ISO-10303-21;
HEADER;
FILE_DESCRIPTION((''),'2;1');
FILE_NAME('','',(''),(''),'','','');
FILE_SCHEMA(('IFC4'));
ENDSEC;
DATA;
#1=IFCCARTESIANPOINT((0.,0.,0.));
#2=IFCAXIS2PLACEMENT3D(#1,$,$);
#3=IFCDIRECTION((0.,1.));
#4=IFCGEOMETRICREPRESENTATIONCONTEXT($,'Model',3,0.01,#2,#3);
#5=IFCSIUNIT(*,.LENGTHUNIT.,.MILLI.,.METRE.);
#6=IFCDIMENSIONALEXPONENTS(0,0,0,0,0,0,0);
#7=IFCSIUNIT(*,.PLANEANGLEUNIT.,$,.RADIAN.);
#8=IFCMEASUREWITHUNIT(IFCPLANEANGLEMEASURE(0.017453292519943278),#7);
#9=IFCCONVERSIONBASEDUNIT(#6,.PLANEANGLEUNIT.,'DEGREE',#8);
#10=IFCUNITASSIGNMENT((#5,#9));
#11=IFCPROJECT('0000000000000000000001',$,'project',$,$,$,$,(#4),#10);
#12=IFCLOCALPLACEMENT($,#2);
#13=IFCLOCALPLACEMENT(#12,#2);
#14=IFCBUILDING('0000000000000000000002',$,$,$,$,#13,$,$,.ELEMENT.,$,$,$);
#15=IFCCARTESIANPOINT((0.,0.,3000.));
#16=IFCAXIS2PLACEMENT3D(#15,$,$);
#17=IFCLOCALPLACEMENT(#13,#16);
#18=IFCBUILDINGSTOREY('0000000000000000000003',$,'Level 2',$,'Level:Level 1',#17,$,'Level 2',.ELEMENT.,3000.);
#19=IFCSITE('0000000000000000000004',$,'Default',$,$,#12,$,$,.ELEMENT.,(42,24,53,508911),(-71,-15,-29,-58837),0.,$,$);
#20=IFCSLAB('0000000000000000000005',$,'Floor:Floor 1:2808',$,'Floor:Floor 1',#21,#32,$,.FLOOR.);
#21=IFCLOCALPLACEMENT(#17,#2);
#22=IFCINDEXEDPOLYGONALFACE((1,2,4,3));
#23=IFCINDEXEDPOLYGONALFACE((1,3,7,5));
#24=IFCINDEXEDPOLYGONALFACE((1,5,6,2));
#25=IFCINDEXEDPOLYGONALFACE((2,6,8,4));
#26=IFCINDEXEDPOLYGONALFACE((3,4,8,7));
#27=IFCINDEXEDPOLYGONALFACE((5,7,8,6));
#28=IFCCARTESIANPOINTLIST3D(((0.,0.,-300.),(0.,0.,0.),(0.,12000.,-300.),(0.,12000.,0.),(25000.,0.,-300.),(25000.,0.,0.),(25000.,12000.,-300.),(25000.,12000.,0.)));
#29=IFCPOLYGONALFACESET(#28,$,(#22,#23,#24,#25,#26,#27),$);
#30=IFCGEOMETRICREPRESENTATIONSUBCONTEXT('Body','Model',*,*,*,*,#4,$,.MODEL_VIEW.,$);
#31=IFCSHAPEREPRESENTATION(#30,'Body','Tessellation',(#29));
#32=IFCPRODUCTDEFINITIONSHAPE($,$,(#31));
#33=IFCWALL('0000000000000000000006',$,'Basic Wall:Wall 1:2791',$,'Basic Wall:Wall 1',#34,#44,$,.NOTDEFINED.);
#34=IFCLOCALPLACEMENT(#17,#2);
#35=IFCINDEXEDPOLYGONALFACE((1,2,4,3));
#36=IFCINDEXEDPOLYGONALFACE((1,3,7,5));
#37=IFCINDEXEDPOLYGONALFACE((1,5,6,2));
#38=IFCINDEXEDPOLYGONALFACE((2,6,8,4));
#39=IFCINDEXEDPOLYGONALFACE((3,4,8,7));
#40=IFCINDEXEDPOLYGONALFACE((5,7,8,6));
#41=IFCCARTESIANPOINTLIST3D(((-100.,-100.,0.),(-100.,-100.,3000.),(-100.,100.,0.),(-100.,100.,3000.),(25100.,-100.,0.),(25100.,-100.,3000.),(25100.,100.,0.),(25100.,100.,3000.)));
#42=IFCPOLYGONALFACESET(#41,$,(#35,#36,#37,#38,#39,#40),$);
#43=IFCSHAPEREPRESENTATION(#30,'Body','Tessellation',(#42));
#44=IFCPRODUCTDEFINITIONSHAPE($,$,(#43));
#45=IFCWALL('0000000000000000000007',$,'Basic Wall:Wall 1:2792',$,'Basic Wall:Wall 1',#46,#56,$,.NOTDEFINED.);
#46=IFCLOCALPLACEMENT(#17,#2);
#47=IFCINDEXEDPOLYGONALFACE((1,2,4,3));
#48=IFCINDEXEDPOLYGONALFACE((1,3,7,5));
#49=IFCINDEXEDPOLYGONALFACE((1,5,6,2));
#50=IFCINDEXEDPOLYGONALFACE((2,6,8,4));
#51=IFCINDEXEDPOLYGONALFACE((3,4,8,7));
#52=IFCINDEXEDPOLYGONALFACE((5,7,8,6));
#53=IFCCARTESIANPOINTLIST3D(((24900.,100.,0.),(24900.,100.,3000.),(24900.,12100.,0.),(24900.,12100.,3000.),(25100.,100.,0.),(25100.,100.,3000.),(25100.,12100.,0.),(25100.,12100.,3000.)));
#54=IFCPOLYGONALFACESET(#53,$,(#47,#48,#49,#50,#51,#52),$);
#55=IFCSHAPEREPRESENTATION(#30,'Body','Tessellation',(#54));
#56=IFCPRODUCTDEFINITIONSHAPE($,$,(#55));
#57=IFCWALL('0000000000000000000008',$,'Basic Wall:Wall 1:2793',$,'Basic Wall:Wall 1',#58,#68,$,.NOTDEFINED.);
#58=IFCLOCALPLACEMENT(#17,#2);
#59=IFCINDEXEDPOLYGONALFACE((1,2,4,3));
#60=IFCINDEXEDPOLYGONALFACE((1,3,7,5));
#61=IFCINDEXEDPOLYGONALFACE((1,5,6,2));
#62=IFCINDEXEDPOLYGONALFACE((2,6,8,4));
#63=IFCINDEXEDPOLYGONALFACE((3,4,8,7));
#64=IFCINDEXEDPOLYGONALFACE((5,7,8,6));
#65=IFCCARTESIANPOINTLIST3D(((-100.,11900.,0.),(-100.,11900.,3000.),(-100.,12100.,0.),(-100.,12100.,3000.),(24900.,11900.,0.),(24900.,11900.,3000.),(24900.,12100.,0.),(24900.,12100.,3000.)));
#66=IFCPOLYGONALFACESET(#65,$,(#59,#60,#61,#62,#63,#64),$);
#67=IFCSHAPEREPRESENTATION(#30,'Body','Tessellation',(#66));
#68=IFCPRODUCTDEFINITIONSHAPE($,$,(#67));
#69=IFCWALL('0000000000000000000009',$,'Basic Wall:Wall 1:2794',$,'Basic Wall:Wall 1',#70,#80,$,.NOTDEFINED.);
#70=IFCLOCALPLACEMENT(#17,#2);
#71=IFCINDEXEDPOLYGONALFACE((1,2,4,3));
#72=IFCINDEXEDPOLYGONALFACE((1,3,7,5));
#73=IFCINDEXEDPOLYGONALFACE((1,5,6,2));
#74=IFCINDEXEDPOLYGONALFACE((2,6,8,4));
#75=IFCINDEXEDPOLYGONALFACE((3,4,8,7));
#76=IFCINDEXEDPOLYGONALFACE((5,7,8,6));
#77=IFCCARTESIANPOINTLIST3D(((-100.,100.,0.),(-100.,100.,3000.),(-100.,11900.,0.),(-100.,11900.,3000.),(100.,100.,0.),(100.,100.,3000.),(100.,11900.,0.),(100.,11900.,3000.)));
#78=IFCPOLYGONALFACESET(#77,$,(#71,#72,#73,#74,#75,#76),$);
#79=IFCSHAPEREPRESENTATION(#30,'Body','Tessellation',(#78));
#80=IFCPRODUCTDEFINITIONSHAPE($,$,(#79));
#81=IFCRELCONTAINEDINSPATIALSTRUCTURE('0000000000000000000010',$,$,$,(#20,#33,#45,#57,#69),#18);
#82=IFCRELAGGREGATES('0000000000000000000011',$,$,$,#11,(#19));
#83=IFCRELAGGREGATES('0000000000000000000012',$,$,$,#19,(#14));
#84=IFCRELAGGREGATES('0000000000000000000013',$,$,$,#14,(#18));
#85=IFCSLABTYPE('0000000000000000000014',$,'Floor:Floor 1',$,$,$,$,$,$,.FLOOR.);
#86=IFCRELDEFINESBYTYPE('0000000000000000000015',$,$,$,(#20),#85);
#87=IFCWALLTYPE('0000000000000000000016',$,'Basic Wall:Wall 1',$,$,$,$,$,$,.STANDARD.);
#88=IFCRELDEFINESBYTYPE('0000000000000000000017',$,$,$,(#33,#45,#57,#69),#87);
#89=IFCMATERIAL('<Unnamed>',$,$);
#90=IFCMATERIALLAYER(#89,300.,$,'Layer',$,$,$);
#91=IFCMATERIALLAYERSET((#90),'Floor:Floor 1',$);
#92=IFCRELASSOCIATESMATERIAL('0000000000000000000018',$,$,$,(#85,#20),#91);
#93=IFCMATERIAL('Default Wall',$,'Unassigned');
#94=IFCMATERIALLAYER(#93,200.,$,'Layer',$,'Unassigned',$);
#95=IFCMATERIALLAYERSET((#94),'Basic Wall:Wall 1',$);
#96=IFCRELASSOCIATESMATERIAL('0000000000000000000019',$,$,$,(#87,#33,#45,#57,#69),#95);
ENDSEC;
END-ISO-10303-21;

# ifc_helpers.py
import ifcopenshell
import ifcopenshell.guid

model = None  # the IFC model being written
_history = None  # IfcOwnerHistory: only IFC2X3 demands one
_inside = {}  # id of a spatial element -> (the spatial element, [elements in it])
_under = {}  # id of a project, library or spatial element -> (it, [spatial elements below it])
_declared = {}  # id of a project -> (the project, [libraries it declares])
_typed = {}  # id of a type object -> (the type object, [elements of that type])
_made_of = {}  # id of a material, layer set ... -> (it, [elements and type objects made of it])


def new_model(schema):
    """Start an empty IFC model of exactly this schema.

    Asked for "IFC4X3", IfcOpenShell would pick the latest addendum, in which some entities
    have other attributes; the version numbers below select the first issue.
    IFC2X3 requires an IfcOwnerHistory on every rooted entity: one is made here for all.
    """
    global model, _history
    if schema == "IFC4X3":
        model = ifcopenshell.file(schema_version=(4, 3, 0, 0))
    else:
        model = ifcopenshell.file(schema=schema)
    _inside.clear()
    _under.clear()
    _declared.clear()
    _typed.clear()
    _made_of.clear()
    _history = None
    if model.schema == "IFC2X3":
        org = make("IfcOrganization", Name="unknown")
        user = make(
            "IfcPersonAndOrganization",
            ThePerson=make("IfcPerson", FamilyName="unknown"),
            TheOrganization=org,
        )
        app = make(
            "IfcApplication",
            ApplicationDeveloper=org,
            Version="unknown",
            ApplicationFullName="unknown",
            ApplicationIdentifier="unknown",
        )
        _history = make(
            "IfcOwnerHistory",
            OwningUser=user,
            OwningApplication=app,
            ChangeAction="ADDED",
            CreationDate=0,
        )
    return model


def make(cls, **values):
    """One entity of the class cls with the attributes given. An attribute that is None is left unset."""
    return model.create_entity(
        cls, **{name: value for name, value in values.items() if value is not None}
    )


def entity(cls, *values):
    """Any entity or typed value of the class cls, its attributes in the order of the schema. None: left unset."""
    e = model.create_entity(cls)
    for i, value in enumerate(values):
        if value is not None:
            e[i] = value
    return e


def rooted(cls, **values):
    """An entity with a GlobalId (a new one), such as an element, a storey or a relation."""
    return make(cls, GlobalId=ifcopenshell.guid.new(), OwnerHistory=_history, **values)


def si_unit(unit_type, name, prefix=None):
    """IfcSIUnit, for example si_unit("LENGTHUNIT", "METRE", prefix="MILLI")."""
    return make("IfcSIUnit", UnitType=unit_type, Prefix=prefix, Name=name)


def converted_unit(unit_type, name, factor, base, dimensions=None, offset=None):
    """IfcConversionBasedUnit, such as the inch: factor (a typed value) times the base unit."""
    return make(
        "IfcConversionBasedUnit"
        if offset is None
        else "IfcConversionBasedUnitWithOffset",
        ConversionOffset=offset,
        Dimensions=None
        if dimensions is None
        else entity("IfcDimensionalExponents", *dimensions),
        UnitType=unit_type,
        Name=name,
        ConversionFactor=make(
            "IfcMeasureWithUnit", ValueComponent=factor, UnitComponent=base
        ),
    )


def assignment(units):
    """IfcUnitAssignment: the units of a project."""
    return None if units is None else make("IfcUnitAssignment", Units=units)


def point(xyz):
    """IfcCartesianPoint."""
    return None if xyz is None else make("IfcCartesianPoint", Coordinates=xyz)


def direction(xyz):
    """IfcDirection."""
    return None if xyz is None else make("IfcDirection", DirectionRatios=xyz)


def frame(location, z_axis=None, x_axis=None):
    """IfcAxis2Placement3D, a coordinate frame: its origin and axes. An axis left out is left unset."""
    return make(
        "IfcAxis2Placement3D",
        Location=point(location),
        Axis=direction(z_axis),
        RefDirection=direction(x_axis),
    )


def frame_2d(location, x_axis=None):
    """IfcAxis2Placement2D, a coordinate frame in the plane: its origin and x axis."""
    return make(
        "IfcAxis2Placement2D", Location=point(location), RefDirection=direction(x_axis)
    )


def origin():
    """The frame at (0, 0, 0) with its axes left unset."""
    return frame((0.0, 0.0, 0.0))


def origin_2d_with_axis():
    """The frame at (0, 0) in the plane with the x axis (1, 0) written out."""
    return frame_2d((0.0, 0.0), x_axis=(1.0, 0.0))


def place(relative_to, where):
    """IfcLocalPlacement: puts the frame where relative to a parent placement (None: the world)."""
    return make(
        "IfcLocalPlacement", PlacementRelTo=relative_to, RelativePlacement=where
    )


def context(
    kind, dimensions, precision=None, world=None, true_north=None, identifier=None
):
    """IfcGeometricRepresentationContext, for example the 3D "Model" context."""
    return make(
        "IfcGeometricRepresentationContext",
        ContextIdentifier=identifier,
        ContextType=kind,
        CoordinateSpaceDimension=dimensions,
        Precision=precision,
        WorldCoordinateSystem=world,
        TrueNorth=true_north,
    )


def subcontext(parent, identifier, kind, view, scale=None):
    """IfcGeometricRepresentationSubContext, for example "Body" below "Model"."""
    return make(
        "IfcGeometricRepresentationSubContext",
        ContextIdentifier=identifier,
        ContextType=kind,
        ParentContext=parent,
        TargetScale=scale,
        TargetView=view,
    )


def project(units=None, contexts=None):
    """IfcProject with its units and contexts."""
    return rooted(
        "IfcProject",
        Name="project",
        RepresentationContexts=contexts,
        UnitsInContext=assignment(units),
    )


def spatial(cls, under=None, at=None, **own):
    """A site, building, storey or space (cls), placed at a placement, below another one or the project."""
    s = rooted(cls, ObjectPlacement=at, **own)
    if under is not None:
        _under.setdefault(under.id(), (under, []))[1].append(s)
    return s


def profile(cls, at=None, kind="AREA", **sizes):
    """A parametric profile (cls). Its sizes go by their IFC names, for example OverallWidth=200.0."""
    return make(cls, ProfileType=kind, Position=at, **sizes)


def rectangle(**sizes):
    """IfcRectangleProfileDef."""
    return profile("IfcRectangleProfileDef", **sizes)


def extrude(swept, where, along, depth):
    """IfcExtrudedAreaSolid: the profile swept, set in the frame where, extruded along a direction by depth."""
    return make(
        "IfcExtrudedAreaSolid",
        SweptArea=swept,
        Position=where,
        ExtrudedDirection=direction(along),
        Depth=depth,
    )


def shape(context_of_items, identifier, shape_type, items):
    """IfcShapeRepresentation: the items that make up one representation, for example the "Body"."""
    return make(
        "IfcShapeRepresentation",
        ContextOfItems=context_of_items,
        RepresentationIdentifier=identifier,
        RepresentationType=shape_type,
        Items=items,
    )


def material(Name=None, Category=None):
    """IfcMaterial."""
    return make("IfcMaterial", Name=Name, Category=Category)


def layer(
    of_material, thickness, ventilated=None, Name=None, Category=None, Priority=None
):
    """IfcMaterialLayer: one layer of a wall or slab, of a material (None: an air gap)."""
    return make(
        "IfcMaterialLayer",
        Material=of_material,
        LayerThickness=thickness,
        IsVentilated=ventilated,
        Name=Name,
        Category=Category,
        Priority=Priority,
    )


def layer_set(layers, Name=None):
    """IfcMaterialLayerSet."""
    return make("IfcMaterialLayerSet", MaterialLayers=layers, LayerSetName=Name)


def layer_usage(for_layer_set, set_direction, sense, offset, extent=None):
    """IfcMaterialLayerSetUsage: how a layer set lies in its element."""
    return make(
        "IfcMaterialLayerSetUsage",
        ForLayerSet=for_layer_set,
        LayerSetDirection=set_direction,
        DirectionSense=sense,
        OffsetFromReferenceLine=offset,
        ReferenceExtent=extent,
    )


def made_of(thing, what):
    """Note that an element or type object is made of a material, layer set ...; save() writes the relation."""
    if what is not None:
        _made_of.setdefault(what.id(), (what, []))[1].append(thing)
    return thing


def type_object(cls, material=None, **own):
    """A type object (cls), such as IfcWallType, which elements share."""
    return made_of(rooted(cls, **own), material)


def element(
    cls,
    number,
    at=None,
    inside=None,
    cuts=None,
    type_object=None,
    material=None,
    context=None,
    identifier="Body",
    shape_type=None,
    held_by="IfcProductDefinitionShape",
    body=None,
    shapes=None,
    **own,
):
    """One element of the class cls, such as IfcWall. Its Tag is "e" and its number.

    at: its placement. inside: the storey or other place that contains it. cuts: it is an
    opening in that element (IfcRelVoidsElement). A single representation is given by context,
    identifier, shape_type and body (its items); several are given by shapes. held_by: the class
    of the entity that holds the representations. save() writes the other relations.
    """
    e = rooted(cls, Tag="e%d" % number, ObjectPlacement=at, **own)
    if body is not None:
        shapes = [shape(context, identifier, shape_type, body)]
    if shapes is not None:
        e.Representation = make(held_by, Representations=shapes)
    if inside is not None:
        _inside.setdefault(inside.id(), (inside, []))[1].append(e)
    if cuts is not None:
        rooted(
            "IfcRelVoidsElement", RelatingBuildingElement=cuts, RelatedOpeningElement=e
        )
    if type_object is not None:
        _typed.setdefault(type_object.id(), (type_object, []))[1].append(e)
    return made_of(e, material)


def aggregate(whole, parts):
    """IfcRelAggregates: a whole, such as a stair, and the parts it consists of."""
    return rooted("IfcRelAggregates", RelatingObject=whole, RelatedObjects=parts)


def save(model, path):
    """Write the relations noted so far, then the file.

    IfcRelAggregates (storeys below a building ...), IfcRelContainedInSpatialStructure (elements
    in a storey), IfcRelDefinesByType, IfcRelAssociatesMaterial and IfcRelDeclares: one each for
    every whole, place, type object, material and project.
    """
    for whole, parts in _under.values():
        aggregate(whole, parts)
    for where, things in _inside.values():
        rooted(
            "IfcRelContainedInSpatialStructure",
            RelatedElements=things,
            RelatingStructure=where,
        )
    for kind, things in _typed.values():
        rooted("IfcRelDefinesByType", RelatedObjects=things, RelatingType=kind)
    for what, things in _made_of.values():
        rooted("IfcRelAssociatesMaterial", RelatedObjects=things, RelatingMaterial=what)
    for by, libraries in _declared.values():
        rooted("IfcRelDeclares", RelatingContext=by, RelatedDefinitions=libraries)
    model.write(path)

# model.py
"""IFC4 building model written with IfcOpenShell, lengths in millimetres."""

from ifc_helpers import new_model, entity, si_unit, converted_unit, direction, frame, frame_2d, origin, origin_2d_with_axis, place, context, subcontext, project, spatial, rectangle, extrude, material, layer, layer_set, layer_usage, type_object, element, save


model = new_model("IFC4")

# Units and contexts
model_context = context("Model", 3, precision=0.01, world=origin(), true_north=direction((0.0, 1.0)))
body_context = subcontext(model_context, "Body", "Model", "MODEL_VIEW")
ifc_project = project(units=[si_unit("LENGTHUNIT", "METRE", prefix="MILLI"), converted_unit("PLANEANGLEUNIT", "DEGREE", entity("IfcPlaneAngleMeasure", 0.017453292519943278), si_unit("PLANEANGLEUNIT", "RADIAN"), dimensions=[0, 0, 0, 0, 0, 0, 0])], contexts=[model_context])

# Site, building, storey
site_placement = place(None, origin())
site = spatial("IfcSite", under=ifc_project, at=site_placement, Name="Default", CompositionType="ELEMENT", RefLatitude=(42, 24, 53, 508911), RefLongitude=(-71, -15, -29, -58837), RefElevation=0.0)
building_placement = place(site_placement, origin())
building = spatial("IfcBuilding", under=site, at=building_placement, CompositionType="ELEMENT")
storey_placement = place(building_placement, frame((0.0, 0.0, 3000.0)))
storey = spatial("IfcBuildingStorey", under=building, at=storey_placement, Name="Level 2", ObjectType="Level:Level 1", LongName="Level 2", CompositionType="ELEMENT", Elevation=3000.0)

# Slab
ifc_material_1 = material(Name="<Unnamed>")
ifc_layer_1 = layer(ifc_material_1, 300.0, Name="Layer")
ifc_layer_set_1 = layer_set([ifc_layer_1], Name="Floor:Floor 1")
ifc_layer_usage_1 = layer_usage(ifc_layer_set_1, "AXIS3", "POSITIVE", 0.0)
slab_type = type_object("IfcSlabType", Name="Floor:Floor 1", PredefinedType="FLOOR", material=ifc_layer_set_1)
slab_placement = place(storey_placement, origin())
element("IfcSlab", 1, at=slab_placement, inside=storey, type_object=slab_type, material=ifc_layer_usage_1, Name="Floor:Floor 1:2808", ObjectType="Floor:Floor 1", PredefinedType="FLOOR", context=body_context, shape_type="SweptSolid", body=[
    extrude(rectangle(XDim=12000.0, YDim=25000.0, at=origin_2d_with_axis()), frame((12500.0, 6000.0, 0.0), z_axis=(0.0, 0.0, -1.0), x_axis=(0.0, 1.0, 0.0)), (0.0, 0.0, 1.0), 300.0),
])

# Walls
ifc_material_2 = material(Name="Default Wall", Category="Unassigned")
ifc_layer_2 = layer(ifc_material_2, 200.0, Name="Layer", Category="Unassigned")
ifc_layer_set_2 = layer_set([ifc_layer_2], Name="Basic Wall:Wall 1")
ifc_layer_usage_2 = layer_usage(ifc_layer_set_2, "AXIS2", "NEGATIVE", 100.0)
wall_type = type_object("IfcWallType", Name="Basic Wall:Wall 1", PredefinedType="STANDARD", material=ifc_layer_set_2)
wall_1_placement = place(storey_placement, frame((-100.0, 0.0, 0.0)))
element("IfcWall", 2, at=wall_1_placement, inside=storey, type_object=wall_type, material=ifc_layer_usage_2, Name="Basic Wall:Wall 1:2791", ObjectType="Basic Wall:Wall 1", PredefinedType="NOTDEFINED", context=body_context, shape_type="SweptSolid", body=[
    extrude(rectangle(XDim=25200.0, YDim=200.0, at=frame_2d((12600.0, 0.0), x_axis=(-1.0, 0.0))), origin(), (0.0, 0.0, 1.0), 3000.0),
])
ifc_layer_usage_3 = layer_usage(ifc_layer_set_2, "AXIS2", "NEGATIVE", 100.0)
wall_2_placement = place(storey_placement, frame((25000.0, 100.0, 0.0), z_axis=(0.0, 0.0, 1.0), x_axis=(0.0, 1.0, 0.0)))
element("IfcWall", 3, at=wall_2_placement, inside=storey, type_object=wall_type, material=ifc_layer_usage_3, Name="Basic Wall:Wall 1:2792", ObjectType="Basic Wall:Wall 1", PredefinedType="NOTDEFINED", context=body_context, shape_type="SweptSolid", body=[
    extrude(rectangle(XDim=12000.0, YDim=200.0, at=frame_2d((6000.0, 0.0), x_axis=(-1.0, 0.0))), origin(), (0.0, 0.0, 1.0), 3000.0),
])
ifc_layer_usage_4 = layer_usage(ifc_layer_set_2, "AXIS2", "NEGATIVE", 100.0)
wall_3_placement = place(storey_placement, frame((24900.0, 12000.0, 0.0), z_axis=(0.0, 0.0, 1.0), x_axis=(-1.0, 0.0, 0.0)))
element("IfcWall", 4, at=wall_3_placement, inside=storey, type_object=wall_type, material=ifc_layer_usage_4, Name="Basic Wall:Wall 1:2793", ObjectType="Basic Wall:Wall 1", PredefinedType="NOTDEFINED", context=body_context, shape_type="SweptSolid", body=[
    extrude(rectangle(XDim=25000.0, YDim=200.0, at=frame_2d((12500.0, 0.0), x_axis=(-1.0, 0.0))), origin(), (0.0, 0.0, 1.0), 3000.0),
])
ifc_layer_usage_5 = layer_usage(ifc_layer_set_2, "AXIS2", "NEGATIVE", 100.0)
wall_4_placement = place(storey_placement, frame((0.0, 11900.0, 0.0), z_axis=(0.0, 0.0, 1.0), x_axis=(0.0, -1.0, 0.0)))
element("IfcWall", 5, at=wall_4_placement, inside=storey, type_object=wall_type, material=ifc_layer_usage_5, Name="Basic Wall:Wall 1:2794", ObjectType="Basic Wall:Wall 1", PredefinedType="NOTDEFINED", context=body_context, shape_type="SweptSolid", body=[
    extrude(rectangle(XDim=11800.0, YDim=200.0, at=frame_2d((5900.0, 0.0), x_axis=(-1.0, 0.0))), origin(), (0.0, 0.0, 1.0), 3000.0),
])

save(model, "model.ifc")
